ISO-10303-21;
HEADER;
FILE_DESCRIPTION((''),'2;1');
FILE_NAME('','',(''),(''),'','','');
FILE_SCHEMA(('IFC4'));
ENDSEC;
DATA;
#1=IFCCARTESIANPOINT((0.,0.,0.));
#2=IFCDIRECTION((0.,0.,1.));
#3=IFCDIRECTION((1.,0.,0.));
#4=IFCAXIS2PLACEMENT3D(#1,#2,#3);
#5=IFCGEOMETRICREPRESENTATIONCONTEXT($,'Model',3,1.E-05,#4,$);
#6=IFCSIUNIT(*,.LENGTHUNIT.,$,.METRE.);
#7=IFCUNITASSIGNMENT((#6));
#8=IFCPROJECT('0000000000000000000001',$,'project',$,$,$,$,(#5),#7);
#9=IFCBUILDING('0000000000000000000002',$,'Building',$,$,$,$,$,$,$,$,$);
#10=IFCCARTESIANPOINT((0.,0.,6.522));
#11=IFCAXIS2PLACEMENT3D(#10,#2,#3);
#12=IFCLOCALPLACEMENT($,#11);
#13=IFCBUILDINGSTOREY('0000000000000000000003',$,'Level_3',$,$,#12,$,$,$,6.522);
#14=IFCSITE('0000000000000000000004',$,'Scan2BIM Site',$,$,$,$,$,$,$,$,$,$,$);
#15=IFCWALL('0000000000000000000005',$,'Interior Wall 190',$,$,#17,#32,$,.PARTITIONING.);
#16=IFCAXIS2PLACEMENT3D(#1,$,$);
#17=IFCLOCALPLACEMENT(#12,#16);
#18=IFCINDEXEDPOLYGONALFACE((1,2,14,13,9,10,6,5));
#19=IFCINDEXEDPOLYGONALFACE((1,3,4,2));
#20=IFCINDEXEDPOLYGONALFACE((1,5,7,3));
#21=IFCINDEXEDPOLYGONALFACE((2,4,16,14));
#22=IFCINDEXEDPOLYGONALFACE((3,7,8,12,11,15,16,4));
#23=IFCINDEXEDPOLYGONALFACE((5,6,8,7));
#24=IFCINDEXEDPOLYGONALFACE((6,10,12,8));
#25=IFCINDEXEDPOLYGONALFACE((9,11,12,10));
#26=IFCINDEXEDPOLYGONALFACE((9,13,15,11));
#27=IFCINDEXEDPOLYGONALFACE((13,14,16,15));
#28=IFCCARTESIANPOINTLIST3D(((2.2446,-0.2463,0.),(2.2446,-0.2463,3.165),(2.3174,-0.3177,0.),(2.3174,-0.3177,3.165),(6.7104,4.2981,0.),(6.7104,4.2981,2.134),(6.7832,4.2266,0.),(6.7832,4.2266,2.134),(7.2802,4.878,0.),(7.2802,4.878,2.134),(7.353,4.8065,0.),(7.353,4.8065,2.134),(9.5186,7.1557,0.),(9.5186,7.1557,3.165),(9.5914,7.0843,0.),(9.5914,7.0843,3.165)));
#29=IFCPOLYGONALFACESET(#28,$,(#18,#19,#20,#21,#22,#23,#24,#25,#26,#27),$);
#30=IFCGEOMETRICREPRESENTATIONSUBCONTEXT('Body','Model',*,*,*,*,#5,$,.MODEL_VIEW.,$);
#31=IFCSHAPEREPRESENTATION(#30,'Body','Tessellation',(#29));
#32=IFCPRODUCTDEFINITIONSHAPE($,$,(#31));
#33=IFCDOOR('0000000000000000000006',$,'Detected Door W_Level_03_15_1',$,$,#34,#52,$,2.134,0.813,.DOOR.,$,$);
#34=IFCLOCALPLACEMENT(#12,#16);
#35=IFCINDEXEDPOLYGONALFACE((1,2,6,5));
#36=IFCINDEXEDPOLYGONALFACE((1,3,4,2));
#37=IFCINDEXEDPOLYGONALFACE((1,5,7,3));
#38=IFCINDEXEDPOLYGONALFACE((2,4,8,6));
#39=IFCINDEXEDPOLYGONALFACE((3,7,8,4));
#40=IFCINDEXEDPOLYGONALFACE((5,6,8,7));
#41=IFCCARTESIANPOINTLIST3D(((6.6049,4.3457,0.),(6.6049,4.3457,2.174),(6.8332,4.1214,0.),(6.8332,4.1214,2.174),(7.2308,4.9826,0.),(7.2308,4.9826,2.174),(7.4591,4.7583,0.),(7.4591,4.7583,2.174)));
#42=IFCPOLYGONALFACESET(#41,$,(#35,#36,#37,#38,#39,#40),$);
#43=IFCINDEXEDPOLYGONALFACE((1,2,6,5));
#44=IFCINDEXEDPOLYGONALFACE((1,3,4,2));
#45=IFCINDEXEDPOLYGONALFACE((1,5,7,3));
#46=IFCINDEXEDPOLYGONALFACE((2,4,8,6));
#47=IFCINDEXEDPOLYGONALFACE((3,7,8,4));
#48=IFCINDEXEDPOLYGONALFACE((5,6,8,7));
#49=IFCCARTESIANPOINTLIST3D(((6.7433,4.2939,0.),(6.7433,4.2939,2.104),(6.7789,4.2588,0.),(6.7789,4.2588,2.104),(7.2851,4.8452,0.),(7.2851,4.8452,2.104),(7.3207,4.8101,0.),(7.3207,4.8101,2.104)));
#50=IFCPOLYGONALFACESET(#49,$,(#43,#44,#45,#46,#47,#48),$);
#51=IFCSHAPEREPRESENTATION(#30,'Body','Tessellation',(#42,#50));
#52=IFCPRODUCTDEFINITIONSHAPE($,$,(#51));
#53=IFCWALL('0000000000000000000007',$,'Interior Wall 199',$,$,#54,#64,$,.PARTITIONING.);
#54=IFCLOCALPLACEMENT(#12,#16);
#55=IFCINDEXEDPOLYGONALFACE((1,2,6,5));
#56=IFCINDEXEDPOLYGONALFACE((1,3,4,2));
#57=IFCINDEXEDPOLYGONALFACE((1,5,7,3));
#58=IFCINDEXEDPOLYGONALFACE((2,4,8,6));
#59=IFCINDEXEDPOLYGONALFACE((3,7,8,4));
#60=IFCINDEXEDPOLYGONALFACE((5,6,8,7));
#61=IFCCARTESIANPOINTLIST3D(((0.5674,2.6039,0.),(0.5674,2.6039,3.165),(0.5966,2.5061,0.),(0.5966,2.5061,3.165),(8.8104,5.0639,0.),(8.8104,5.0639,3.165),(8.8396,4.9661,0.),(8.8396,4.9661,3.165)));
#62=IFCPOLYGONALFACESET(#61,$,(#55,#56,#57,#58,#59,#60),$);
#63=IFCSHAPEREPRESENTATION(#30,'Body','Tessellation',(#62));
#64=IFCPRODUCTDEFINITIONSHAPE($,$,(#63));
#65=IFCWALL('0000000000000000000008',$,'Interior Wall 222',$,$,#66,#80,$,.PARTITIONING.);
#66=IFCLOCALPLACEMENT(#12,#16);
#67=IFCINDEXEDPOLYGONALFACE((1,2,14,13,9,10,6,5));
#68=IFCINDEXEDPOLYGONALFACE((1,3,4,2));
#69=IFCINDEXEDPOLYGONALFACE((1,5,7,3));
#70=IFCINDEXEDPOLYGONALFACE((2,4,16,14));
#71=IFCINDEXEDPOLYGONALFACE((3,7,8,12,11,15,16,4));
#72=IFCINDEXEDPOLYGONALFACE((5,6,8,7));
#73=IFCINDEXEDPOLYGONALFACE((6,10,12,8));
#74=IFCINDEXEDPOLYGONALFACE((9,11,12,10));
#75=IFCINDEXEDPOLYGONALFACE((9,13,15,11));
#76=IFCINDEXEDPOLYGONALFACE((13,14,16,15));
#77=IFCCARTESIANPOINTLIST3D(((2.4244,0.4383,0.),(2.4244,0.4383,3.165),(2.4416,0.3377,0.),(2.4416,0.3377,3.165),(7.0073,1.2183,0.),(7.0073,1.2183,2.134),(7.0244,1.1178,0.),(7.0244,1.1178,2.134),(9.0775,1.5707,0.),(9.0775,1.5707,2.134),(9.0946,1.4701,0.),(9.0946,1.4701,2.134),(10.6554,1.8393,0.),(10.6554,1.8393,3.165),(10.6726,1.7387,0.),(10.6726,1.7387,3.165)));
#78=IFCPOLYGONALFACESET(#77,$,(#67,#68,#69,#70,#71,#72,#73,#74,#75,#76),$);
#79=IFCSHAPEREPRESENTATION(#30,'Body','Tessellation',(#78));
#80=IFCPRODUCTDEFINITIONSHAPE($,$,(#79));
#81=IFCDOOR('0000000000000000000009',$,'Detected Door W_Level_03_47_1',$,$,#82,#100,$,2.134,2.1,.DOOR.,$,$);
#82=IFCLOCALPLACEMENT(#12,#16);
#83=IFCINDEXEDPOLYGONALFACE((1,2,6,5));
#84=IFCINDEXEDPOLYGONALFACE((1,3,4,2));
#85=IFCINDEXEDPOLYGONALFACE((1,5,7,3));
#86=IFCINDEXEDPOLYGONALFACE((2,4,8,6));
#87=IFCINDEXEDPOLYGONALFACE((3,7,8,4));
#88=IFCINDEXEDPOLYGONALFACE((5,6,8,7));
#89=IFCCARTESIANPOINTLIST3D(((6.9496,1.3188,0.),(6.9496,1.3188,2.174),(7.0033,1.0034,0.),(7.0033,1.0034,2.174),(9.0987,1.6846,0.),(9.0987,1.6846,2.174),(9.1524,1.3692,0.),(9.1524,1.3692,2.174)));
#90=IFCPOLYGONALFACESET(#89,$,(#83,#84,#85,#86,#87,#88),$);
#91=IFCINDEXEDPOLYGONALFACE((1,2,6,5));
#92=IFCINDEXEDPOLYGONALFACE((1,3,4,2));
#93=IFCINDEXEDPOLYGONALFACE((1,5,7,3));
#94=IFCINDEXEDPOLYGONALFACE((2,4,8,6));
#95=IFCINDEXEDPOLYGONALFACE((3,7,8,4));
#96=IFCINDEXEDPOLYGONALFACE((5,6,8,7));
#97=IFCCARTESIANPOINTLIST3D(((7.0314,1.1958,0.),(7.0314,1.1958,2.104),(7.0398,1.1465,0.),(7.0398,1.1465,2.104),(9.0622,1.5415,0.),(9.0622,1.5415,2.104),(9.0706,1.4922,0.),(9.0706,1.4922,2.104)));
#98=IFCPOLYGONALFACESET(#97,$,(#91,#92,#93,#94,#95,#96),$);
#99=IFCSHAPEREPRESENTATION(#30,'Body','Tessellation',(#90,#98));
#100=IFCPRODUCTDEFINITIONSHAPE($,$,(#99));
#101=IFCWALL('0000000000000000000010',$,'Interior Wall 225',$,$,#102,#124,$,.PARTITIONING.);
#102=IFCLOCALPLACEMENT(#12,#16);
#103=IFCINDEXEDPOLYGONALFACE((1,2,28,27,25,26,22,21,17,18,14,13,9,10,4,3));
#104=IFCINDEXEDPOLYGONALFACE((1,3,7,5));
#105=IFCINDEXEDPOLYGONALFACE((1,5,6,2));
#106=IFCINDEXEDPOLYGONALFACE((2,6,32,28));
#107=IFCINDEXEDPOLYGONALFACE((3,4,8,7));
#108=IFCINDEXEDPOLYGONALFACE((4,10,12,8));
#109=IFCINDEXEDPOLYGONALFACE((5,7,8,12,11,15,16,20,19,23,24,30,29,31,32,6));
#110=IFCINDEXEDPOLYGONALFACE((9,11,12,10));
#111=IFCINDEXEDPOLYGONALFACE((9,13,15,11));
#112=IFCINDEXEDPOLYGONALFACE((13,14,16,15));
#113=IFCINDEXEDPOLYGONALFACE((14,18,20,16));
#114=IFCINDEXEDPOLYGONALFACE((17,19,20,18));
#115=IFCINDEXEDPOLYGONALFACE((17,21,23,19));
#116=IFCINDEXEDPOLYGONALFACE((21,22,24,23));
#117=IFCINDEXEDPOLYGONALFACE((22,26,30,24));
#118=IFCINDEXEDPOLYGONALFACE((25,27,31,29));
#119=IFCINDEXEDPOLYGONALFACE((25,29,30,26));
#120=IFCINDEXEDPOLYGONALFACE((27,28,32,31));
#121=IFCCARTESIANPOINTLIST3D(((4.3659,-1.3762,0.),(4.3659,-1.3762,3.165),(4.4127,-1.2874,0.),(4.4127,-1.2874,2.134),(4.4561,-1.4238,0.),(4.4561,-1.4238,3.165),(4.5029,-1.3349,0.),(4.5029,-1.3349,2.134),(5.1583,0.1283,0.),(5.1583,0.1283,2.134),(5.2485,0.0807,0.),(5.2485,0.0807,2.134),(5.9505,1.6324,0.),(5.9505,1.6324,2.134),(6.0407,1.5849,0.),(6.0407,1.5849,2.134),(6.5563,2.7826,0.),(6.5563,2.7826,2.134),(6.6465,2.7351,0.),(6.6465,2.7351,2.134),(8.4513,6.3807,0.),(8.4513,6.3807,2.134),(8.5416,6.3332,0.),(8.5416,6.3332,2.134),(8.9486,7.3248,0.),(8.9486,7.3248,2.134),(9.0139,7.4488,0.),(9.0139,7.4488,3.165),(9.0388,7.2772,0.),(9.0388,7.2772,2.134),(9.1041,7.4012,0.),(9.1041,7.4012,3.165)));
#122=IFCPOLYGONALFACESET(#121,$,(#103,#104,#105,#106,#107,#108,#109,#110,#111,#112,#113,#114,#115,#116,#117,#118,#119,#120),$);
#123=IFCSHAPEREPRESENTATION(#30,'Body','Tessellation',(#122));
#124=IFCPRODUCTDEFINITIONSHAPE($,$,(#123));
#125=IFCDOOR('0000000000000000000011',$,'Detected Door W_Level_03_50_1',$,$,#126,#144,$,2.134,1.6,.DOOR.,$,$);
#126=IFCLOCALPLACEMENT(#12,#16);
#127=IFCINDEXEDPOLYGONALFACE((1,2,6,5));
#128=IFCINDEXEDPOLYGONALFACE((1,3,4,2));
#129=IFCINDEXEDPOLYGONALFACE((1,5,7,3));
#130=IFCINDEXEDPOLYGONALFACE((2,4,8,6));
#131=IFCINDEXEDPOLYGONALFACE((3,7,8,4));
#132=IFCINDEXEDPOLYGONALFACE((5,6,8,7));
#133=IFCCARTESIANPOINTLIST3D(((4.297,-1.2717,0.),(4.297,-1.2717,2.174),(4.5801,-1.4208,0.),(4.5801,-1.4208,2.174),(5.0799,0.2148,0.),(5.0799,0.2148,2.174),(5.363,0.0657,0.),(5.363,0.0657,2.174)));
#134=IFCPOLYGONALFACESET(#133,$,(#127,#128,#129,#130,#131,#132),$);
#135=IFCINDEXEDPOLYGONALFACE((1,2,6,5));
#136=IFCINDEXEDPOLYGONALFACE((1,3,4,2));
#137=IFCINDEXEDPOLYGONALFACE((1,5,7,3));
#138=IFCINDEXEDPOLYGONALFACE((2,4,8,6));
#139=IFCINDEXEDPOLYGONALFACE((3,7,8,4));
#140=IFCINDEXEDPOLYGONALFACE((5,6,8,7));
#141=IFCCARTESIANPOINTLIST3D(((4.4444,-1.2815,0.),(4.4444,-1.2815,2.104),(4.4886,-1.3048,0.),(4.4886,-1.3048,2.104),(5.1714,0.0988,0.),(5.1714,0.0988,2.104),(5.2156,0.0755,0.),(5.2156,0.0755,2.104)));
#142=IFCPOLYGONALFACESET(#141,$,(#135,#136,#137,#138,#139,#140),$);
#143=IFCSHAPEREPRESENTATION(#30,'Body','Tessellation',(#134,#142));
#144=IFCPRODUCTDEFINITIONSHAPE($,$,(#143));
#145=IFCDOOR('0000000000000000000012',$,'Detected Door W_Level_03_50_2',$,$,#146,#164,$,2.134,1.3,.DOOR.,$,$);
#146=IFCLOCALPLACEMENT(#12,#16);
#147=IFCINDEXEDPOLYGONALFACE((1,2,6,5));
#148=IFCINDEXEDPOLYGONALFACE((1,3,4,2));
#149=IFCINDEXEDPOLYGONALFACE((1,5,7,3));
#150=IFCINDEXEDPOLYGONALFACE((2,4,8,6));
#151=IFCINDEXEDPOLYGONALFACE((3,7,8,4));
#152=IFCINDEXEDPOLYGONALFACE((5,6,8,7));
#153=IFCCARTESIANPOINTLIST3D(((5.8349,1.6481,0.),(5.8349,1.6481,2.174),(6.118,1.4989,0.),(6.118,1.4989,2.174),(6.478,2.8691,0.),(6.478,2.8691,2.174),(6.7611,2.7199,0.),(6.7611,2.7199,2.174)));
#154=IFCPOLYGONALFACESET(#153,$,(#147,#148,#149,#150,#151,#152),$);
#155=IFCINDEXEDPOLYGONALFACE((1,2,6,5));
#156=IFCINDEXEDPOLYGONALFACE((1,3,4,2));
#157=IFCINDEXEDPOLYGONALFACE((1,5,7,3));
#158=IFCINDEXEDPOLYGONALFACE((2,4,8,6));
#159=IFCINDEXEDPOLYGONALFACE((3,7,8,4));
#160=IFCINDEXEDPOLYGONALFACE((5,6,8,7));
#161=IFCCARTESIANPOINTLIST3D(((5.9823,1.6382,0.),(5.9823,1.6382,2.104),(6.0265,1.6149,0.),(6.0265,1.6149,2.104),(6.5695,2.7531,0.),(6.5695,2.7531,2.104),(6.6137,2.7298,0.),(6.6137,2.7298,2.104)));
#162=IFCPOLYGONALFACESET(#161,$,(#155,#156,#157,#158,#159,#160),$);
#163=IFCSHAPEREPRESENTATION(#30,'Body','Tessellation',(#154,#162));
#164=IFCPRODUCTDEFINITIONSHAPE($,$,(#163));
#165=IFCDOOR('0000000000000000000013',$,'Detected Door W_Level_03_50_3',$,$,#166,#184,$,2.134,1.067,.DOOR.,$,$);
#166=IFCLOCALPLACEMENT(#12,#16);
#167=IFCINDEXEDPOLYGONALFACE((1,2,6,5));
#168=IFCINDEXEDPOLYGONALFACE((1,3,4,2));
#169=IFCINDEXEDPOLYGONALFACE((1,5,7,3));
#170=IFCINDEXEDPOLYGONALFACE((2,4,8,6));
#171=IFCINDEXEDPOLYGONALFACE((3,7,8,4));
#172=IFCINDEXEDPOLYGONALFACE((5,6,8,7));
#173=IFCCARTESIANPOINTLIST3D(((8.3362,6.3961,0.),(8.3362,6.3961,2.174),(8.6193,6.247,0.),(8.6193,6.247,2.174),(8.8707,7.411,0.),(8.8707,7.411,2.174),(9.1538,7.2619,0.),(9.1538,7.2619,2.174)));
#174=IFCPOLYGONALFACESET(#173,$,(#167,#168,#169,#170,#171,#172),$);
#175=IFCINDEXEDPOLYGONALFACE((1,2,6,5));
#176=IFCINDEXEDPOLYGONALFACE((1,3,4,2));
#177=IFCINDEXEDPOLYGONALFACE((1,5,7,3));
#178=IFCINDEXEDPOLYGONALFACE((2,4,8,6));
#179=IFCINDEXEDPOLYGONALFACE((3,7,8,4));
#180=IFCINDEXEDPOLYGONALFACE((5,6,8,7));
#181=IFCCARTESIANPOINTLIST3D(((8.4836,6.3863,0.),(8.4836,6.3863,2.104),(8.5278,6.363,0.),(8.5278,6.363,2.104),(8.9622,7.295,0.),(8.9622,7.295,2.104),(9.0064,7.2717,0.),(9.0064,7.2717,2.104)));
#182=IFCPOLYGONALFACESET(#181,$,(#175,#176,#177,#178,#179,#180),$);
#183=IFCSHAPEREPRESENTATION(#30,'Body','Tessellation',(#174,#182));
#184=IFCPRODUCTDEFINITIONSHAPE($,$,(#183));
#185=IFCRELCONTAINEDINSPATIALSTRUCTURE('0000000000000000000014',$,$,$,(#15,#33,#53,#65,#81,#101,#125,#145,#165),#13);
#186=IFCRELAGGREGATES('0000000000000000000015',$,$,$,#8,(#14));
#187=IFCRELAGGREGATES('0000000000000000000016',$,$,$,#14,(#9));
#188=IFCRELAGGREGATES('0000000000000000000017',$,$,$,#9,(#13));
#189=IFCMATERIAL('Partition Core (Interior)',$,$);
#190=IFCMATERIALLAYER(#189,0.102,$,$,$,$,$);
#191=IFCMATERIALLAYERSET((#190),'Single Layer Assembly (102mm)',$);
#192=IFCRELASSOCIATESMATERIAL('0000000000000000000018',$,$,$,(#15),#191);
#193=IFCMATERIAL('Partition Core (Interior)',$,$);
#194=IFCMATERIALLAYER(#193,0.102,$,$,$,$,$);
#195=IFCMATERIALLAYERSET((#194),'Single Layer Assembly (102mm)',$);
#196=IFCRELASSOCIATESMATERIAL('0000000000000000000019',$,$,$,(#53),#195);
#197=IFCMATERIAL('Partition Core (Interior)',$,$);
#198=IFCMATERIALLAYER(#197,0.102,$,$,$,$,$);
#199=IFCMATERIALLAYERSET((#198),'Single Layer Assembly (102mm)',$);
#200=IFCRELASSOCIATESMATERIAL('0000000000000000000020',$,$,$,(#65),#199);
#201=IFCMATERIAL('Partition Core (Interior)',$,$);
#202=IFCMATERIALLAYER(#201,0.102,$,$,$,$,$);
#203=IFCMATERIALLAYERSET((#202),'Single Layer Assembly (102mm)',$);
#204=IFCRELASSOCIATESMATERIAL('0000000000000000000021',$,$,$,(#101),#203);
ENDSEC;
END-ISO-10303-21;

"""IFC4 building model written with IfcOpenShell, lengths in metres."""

from ifc_helpers import new_model, si_unit, frame, origin, origin_with_axes, place, context, subcontext, project, spatial, rectangle, extrude, material, layer, layer_set, element, fill, save


model = new_model("IFC4")

# Units and contexts
model_context = context("Model", 3, precision=1e-05, world=origin_with_axes())
body_context = subcontext(model_context, "Body", "Model", "MODEL_VIEW")
ifc_project = project(units=[si_unit("LENGTHUNIT", "METRE")], contexts=[model_context])

# Site, building, storey
site = spatial("IfcSite", under=ifc_project, Name="Scan2BIM Site")
building = spatial("IfcBuilding", under=site, Name="Building")
storey_placement = place(None, frame((0.0, 0.0, 6.522), z_axis=(0.0, 0.0, 1.0), x_axis=(1.0, 0.0, 0.0)))
storey = spatial("IfcBuildingStorey", under=building, at=storey_placement, Name="Level_3", Elevation=6.522)

# Wall, opening, door
ifc_material_1 = material(Name="Partition Core (Interior)")
ifc_layer_1 = layer(ifc_material_1, 0.102)
ifc_layer_set_1 = layer_set([ifc_layer_1], Name="Single Layer Assembly (102mm)")
wall_1_placement = place(storey_placement, frame((5.918, 3.419, 0.0), z_axis=(0.0, 0.0, 1.0), x_axis=(-0.700913, -0.713247, 0.0)))
wall_1 = element("IfcWall", 1, at=wall_1_placement, inside=storey, material=ifc_layer_set_1, Name="Interior Wall 190", PredefinedType="PARTITIONING", context=body_context, shape_type="SweptSolid", body=[
    extrude(rectangle(XDim=10.3779, YDim=0.102), origin(), (0.0, 0.0, 1.0), 3.165),
])
opening_1_placement = place(None, frame((7.032, 4.552, 6.522), z_axis=(0.0, 0.0, 1.0), x_axis=(-0.700913, -0.713247, 0.0)))
opening_1 = element("IfcOpeningElement", 2, at=opening_1_placement, cuts=wall_1, PredefinedType="OPENING", context=body_context, shape_type="SweptSolid", body=[
    extrude(rectangle(XDim=0.813, YDim=0.202), origin(), (0.0, 0.0, 1.0), 2.134),
])
door_1_placement = place(opening_1_placement, frame((0.0, 0.0, 0.0), z_axis=(0.0, 0.0, 1.0), x_axis=(1.0, 0.0, 0.0)))
door_1 = element("IfcDoor", 3, at=door_1_placement, inside=storey, Name="Detected Door W_Level_03_15_1", OverallHeight=2.134, OverallWidth=0.813, PredefinedType="DOOR", context=body_context, shape_type="SweptSolid", body=[
    extrude(rectangle(XDim=0.893, YDim=0.32), origin(), (0.0, 0.0, 1.0), 2.174),
    extrude(rectangle(XDim=0.773, YDim=0.05), origin(), (0.0, 0.0, 1.0), 2.104),
])
fill(opening_1, door_1)

# Wall
ifc_material_2 = material(Name="Partition Core (Interior)")
ifc_layer_2 = layer(ifc_material_2, 0.102)
ifc_layer_set_2 = layer_set([ifc_layer_2], Name="Single Layer Assembly (102mm)")
wall_2_placement = place(storey_placement, frame((4.7035, 3.785, 0.0), z_axis=(0.0, 0.0, 1.0), x_axis=(-0.958238, -0.285972, 0.0)))
element("IfcWall", 4, at=wall_2_placement, inside=storey, material=ifc_layer_set_2, Name="Interior Wall 199", PredefinedType="PARTITIONING", context=body_context, shape_type="SweptSolid", body=[
    extrude(rectangle(XDim=8.6022, YDim=0.102), origin(), (0.0, 0.0, 1.0), 3.165),
])

# Wall, opening, door
ifc_material_3 = material(Name="Partition Core (Interior)")
ifc_layer_3 = layer(ifc_material_3, 0.102)
ifc_layer_set_3 = layer_set([ifc_layer_3], Name="Single Layer Assembly (102mm)")
wall_3_placement = place(storey_placement, frame((6.5485, 1.0885, 0.0), z_axis=(0.0, 0.0, 1.0), x_axis=(-0.985822, -0.167797, 0.0)))
wall_3 = element("IfcWall", 5, at=wall_3_placement, inside=storey, material=ifc_layer_set_3, Name="Interior Wall 222", PredefinedType="PARTITIONING", context=body_context, shape_type="SweptSolid", body=[
    extrude(rectangle(XDim=8.3494, YDim=0.102), origin(), (0.0, 0.0, 1.0), 3.165),
])
opening_2_placement = place(None, frame((8.051, 1.344, 6.522), z_axis=(0.0, 0.0, 1.0), x_axis=(-0.985822, -0.167797, 0.0)))
opening_2 = element("IfcOpeningElement", 6, at=opening_2_placement, cuts=wall_3, PredefinedType="OPENING", context=body_context, shape_type="SweptSolid", body=[
    extrude(rectangle(XDim=2.1, YDim=0.202), origin(), (0.0, 0.0, 1.0), 2.134),
])
door_2_placement = place(opening_2_placement, frame((0.0, 0.0, 0.0), z_axis=(0.0, 0.0, 1.0), x_axis=(1.0, 0.0, 0.0)))
door_2 = element("IfcDoor", 7, at=door_2_placement, inside=storey, Name="Detected Door W_Level_03_47_1", OverallHeight=2.134, OverallWidth=2.1, PredefinedType="DOOR", context=body_context, shape_type="SweptSolid", body=[
    extrude(rectangle(XDim=2.18, YDim=0.32), origin(), (0.0, 0.0, 1.0), 2.174),
    extrude(rectangle(XDim=2.06, YDim=0.05), origin(), (0.0, 0.0, 1.0), 2.104),
])
fill(opening_2, door_2)

# Wall, openings, doors
ifc_material_4 = material(Name="Partition Core (Interior)")
ifc_layer_4 = layer(ifc_material_4, 0.102)
ifc_layer_set_4 = layer_set([ifc_layer_4], Name="Single Layer Assembly (102mm)")
wall_4_placement = place(storey_placement, frame((6.735, 3.0125, 0.0), z_axis=(0.0, 0.0, 1.0), x_axis=(0.466003, 0.884783, 0.0)))
wall_4 = element("IfcWall", 8, at=wall_4_placement, inside=storey, material=ifc_layer_set_4, Name="Interior Wall 225", PredefinedType="PARTITIONING", context=body_context, shape_type="SweptSolid", body=[
    extrude(rectangle(XDim=9.9742, YDim=0.102), origin(), (0.0, 0.0, 1.0), 3.165),
])
opening_3_placement = place(None, frame((4.83, -0.603, 6.522), z_axis=(0.0, 0.0, 1.0), x_axis=(0.466003, 0.884783, 0.0)))
opening_3 = element("IfcOpeningElement", 9, at=opening_3_placement, cuts=wall_4, PredefinedType="OPENING", context=body_context, shape_type="SweptSolid", body=[
    extrude(rectangle(XDim=1.6, YDim=0.202), origin(), (0.0, 0.0, 1.0), 2.134),
])
opening_4_placement = place(None, frame((6.298, 2.184, 6.522), z_axis=(0.0, 0.0, 1.0), x_axis=(0.466003, 0.884783, 0.0)))
opening_4 = element("IfcOpeningElement", 10, at=opening_4_placement, cuts=wall_4, PredefinedType="OPENING", context=body_context, shape_type="SweptSolid", body=[
    extrude(rectangle(XDim=1.3, YDim=0.202), origin(), (0.0, 0.0, 1.0), 2.134),
])
opening_5_placement = place(None, frame((8.745, 6.829, 6.522), z_axis=(0.0, 0.0, 1.0), x_axis=(0.466003, 0.884783, 0.0)))
opening_5 = element("IfcOpeningElement", 11, at=opening_5_placement, cuts=wall_4, PredefinedType="OPENING", context=body_context, shape_type="SweptSolid", body=[
    extrude(rectangle(XDim=1.067, YDim=0.202), origin(), (0.0, 0.0, 1.0), 2.134),
])
door_3_placement = place(opening_3_placement, frame((0.0, 0.0, 0.0), z_axis=(0.0, 0.0, 1.0), x_axis=(1.0, 0.0, 0.0)))
door_3 = element("IfcDoor", 12, at=door_3_placement, inside=storey, Name="Detected Door W_Level_03_50_1", OverallHeight=2.134, OverallWidth=1.6, PredefinedType="DOOR", context=body_context, shape_type="SweptSolid", body=[
    extrude(rectangle(XDim=1.68, YDim=0.32), origin(), (0.0, 0.0, 1.0), 2.174),
    extrude(rectangle(XDim=1.56, YDim=0.05), origin(), (0.0, 0.0, 1.0), 2.104),
])
fill(opening_3, door_3)
door_4_placement = place(opening_4_placement, frame((0.0, 0.0, 0.0), z_axis=(0.0, 0.0, 1.0), x_axis=(1.0, 0.0, 0.0)))
door_4 = element("IfcDoor", 13, at=door_4_placement, inside=storey, Name="Detected Door W_Level_03_50_2", OverallHeight=2.134, OverallWidth=1.3, PredefinedType="DOOR", context=body_context, shape_type="SweptSolid", body=[
    extrude(rectangle(XDim=1.38, YDim=0.32), origin(), (0.0, 0.0, 1.0), 2.174),
    extrude(rectangle(XDim=1.26, YDim=0.05), origin(), (0.0, 0.0, 1.0), 2.104),
])
fill(opening_4, door_4)
door_5_placement = place(opening_5_placement, frame((0.0, 0.0, 0.0), z_axis=(0.0, 0.0, 1.0), x_axis=(1.0, 0.0, 0.0)))
door_5 = element("IfcDoor", 14, at=door_5_placement, inside=storey, Name="Detected Door W_Level_03_50_3", OverallHeight=2.134, OverallWidth=1.067, PredefinedType="DOOR", context=body_context, shape_type="SweptSolid", body=[
    extrude(rectangle(XDim=1.147, YDim=0.32), origin(), (0.0, 0.0, 1.0), 2.174),
    extrude(rectangle(XDim=1.027, YDim=0.05), origin(), (0.0, 0.0, 1.0), 2.104),
])
fill(opening_5, door_5)

save(model, "model.ifc")
